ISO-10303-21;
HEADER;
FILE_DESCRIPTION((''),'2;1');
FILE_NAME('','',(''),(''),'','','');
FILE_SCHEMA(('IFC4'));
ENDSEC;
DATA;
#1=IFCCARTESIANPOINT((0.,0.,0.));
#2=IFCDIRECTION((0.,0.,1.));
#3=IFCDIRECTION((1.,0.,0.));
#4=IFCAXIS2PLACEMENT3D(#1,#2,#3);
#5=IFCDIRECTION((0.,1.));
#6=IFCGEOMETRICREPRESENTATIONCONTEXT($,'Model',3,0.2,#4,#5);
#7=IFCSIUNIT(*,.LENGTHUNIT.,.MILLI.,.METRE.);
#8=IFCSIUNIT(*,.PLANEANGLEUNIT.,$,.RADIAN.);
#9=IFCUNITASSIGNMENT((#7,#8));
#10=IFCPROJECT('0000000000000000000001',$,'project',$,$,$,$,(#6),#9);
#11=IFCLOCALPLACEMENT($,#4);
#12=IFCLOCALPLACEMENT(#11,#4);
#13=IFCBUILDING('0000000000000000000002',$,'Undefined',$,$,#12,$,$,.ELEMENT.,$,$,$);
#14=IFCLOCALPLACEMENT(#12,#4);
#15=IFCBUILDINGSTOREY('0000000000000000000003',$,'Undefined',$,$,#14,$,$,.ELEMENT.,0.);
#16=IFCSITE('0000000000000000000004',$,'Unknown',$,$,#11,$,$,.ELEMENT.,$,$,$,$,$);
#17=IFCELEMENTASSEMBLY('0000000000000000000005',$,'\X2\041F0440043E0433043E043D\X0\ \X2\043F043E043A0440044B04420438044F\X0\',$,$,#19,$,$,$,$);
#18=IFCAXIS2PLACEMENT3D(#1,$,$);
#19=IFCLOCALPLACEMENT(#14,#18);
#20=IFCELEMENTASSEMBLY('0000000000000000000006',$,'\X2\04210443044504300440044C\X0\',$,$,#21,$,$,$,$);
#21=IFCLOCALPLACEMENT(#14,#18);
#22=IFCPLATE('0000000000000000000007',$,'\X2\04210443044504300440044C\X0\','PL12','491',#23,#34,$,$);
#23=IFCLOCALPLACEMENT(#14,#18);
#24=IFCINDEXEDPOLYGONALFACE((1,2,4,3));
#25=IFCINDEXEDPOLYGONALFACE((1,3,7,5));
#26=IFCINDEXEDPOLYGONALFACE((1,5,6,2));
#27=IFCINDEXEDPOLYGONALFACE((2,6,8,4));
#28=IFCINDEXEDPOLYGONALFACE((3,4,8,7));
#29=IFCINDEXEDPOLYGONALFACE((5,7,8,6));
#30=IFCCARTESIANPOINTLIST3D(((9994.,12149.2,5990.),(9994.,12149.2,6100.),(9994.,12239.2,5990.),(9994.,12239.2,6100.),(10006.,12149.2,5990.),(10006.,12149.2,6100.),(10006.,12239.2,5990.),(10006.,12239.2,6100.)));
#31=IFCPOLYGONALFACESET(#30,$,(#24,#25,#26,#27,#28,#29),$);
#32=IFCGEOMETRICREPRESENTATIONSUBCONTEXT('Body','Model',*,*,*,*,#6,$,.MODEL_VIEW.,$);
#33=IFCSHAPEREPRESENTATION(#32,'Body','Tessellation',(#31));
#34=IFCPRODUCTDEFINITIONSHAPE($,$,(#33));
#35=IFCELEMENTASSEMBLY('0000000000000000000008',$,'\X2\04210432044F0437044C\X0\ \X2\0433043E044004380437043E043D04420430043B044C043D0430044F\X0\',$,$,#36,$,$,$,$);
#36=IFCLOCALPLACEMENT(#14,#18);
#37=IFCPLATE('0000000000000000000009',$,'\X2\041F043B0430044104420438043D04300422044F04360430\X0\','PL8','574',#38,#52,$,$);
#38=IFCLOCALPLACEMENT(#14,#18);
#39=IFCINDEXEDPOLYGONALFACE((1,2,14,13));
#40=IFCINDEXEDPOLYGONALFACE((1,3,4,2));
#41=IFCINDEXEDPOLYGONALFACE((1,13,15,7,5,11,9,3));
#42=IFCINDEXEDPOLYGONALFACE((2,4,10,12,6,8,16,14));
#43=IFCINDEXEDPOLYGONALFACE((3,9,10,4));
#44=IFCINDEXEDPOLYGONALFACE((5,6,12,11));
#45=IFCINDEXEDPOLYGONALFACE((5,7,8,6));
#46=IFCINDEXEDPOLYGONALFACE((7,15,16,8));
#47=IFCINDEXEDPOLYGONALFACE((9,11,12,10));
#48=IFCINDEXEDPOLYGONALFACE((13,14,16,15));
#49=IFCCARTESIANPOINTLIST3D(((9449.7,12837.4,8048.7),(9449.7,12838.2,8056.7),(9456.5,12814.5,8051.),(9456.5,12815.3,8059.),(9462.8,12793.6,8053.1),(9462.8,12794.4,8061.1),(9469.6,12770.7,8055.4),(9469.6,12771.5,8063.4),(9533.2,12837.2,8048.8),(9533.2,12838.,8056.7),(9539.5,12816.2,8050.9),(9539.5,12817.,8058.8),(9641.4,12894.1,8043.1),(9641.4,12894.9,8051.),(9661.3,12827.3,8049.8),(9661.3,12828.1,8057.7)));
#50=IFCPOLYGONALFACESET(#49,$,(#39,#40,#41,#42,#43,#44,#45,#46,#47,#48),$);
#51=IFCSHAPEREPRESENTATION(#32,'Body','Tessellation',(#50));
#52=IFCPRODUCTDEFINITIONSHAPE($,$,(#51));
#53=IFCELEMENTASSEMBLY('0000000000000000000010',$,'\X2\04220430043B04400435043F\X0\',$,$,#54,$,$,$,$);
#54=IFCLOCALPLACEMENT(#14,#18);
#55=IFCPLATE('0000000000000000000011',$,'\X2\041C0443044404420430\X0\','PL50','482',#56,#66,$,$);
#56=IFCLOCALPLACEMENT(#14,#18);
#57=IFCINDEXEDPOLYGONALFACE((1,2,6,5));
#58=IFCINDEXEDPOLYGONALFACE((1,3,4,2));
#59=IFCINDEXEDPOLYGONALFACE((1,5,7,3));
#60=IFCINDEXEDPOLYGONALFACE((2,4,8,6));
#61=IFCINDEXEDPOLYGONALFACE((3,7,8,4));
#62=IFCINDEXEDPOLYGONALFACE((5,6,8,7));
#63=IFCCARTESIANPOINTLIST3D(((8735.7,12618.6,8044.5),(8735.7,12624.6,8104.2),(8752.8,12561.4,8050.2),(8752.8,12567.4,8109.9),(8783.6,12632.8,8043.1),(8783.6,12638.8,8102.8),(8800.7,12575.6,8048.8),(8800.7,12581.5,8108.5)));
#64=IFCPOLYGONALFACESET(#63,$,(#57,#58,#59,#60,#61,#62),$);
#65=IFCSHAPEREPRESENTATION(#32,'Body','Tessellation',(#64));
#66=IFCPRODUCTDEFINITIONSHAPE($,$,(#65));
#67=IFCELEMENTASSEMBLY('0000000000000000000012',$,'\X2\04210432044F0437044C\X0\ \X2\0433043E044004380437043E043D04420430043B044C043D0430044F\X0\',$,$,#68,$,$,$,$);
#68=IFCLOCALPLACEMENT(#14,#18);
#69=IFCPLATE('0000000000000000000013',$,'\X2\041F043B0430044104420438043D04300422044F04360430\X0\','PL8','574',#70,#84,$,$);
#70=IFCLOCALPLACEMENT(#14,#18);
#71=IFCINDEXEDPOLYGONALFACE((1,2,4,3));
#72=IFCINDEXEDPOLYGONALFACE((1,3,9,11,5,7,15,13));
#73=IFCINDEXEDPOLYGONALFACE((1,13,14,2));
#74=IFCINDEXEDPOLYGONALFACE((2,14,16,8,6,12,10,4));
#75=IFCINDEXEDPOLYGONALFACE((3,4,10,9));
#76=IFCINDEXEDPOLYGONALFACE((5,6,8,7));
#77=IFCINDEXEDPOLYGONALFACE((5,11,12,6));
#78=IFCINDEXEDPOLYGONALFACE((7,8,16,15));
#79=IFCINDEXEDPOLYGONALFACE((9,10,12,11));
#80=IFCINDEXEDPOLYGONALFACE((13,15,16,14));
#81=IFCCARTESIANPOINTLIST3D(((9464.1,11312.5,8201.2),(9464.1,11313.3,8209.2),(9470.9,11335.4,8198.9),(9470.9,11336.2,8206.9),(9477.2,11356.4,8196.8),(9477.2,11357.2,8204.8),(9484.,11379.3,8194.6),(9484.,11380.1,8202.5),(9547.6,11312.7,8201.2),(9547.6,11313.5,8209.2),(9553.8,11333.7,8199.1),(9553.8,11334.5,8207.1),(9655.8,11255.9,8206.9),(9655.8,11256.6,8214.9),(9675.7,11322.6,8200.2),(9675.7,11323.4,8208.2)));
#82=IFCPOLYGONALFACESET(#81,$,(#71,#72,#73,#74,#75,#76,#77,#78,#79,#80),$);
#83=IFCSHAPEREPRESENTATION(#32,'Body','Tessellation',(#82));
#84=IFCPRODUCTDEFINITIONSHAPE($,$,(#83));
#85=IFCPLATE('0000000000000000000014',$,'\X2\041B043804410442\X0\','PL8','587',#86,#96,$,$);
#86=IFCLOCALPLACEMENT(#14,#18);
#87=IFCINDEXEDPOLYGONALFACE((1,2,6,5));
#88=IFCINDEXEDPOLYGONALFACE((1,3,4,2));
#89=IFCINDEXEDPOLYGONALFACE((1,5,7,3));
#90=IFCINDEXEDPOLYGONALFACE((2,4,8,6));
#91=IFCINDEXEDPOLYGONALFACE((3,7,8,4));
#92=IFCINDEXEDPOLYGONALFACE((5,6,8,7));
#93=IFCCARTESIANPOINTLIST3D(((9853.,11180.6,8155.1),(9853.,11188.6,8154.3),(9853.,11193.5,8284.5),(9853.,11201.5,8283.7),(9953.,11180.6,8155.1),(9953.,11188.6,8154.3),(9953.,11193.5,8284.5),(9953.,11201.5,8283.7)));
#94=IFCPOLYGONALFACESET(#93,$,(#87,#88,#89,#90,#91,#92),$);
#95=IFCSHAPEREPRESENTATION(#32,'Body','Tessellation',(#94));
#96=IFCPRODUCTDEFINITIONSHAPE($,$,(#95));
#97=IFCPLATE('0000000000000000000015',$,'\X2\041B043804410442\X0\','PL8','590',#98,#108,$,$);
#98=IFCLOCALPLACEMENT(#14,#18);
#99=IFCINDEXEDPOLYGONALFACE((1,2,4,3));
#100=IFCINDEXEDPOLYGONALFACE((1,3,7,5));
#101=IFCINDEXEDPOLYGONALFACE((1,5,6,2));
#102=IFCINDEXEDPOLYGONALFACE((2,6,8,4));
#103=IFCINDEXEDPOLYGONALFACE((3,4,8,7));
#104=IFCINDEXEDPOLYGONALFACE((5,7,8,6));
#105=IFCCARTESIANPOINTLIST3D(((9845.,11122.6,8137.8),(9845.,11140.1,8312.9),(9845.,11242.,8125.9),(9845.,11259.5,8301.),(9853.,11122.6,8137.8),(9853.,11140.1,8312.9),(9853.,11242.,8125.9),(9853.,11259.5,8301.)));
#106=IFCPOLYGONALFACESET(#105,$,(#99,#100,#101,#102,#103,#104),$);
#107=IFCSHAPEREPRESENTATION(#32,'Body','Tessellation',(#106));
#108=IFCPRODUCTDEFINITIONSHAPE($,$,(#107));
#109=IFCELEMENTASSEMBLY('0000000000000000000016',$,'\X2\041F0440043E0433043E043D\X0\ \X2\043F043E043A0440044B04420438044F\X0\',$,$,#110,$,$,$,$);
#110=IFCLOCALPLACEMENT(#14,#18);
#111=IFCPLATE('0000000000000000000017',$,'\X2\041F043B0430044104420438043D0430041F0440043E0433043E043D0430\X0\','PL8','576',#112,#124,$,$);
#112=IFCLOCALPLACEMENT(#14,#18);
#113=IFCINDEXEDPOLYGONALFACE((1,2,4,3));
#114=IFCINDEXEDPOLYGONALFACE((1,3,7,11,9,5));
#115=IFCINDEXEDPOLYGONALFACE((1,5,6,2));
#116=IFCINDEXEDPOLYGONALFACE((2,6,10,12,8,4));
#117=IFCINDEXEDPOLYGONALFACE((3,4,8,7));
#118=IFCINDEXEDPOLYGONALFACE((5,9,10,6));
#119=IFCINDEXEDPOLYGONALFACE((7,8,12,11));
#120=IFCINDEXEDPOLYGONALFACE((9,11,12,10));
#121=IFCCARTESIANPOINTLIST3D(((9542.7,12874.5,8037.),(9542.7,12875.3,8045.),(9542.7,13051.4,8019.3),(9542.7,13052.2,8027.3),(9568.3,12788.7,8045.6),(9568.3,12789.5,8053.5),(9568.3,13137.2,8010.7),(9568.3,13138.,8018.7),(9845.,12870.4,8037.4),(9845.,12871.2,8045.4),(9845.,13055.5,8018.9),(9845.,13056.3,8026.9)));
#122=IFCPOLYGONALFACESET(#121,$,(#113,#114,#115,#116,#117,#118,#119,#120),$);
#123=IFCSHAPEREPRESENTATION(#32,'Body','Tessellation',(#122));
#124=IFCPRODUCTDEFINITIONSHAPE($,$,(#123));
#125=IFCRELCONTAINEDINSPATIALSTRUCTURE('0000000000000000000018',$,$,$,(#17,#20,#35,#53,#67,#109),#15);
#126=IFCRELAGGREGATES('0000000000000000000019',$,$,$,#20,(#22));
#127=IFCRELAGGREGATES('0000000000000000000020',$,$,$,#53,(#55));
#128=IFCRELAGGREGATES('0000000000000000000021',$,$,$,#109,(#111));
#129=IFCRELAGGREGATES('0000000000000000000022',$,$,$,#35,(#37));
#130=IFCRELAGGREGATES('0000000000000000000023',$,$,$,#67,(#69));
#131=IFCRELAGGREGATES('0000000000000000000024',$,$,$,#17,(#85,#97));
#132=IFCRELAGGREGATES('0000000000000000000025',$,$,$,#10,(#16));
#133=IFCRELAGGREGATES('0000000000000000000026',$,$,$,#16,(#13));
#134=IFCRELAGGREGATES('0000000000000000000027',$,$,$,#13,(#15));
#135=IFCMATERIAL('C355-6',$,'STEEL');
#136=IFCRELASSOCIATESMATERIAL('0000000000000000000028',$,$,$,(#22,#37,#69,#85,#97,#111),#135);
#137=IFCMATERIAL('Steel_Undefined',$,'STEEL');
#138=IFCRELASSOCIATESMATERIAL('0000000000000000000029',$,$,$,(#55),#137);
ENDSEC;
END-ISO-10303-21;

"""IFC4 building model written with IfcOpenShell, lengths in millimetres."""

from ifc_helpers import new_model, si_unit, direction, frame, origin_with_axes, place, context, subcontext, project, spatial, line, indexed_curve, outline, extrude, material, element, aggregate, save


model = new_model("IFC4")

# Units and contexts
model_context = context("Model", 3, precision=0.2, world=origin_with_axes(), true_north=direction((0.0, 1.0)))
body_context = subcontext(model_context, "Body", "Model", "MODEL_VIEW")
ifc_project = project(units=[si_unit("LENGTHUNIT", "METRE", prefix="MILLI"), si_unit("PLANEANGLEUNIT", "RADIAN")], contexts=[model_context])

# Site, building, storey
site_placement = place(None, origin_with_axes())
site = spatial("IfcSite", under=ifc_project, at=site_placement, Name="Unknown", CompositionType="ELEMENT")
building_placement = place(site_placement, origin_with_axes())
building = spatial("IfcBuilding", under=site, at=building_placement, Name="Undefined", CompositionType="ELEMENT")
storey_placement = place(building_placement, origin_with_axes())
storey = spatial("IfcBuildingStorey", under=building, at=storey_placement, Name="Undefined", CompositionType="ELEMENT", Elevation=0.0)

# Shared definitions
ifc_material_1 = material(Name="C355-6", Category="STEEL")

# Element assembly
assembly_1_placement = place(storey_placement, frame((10000.0, 11191.0, 8219.4), z_axis=(0.0, -0.995037, 0.099504), x_axis=(-1.0, 0.0, 0.0)))
assembly_1 = element("IfcElementAssembly", 1, at=assembly_1_placement, inside=storey, Name="Прогон покрытия")

# Element assembly, plate
assembly_2_placement = place(storey_placement, frame((10000.0, 12149.2, 6100.0), z_axis=(-1.0, 0.0, 0.0), x_axis=(0.0, 1.0, 0.0)))
assembly_2 = element("IfcElementAssembly", 2, at=assembly_2_placement, inside=storey, Name="Сухарь")
plate_1_placement = place(assembly_2_placement, origin_with_axes())
plate_1 = element("IfcPlate", 3, at=plate_1_placement, material=ifc_material_1, Name="Сухарь", Description="PL12", ObjectType="491", context=body_context, shape_type="SolidModel", body=[
    extrude(outline(indexed_curve([(0.0, 0.0), (90.0, 0.0), (90.0, 110.0), (0.0, 110.0)], segments=[line(1, 2, 3, 4, 1)])), frame((0.0, 0.0, 6.0), z_axis=(0.0, 0.0, 1.0), x_axis=(1.0, 0.0, 0.0)), (0.0, 0.0, -1.0), 12.0),
])
aggregate(assembly_2, [plate_1])

# Element assembly, plate, voiding feature
assembly_3_placement = place(storey_placement, frame((8657.9, 12567.5, 8079.8), z_axis=(0.28473, -0.95385, 0.095385), x_axis=(0.958608, 0.283317, -0.028332)))
assembly_3 = element("IfcElementAssembly", 4, at=assembly_3_placement, inside=storey, Name="Связь горизонтальная")
plate_2_placement = place(assembly_3_placement, frame((1036.3, 0.0, 35.0), z_axis=(0.0, 1.0, 0.0), x_axis=(0.0, 0.0, -1.0)))
plate_2 = element("IfcPlate", 5, at=plate_2_placement, material=ifc_material_1, Name="ПластинаТяжа", Description="PL8", ObjectType="574", context=body_context, shape_type="SolidModel", body=[
    extrude(outline(indexed_curve([(0.0, 0.0), (70.0, 0.0), (70.0, 200.0), (0.0, 200.0)], segments=[line(1, 2, 3, 4, 1)])), frame((0.0, 0.0, 4.0), z_axis=(0.0, 0.0, 1.0), x_axis=(1.0, 0.0, 0.0)), (0.0, 0.0, -1.0), 8.0),
])
voiding_feature_1_placement = place(plate_2_placement, frame((24.0, 120.0, 0.0), z_axis=(0.0, 0.0, 1.0), x_axis=(1.0, 0.0, 0.0)))
element("IfcVoidingFeature", 6, at=voiding_feature_1_placement, cuts=plate_2, Name="PLATE", ObjectType="(?)", PredefinedType="HOLE", context=body_context, shape_type="SolidModel", body=[
    extrude(outline(indexed_curve([(0.0, 0.0), (22.0, 0.0), (22.0, 85.0), (0.0, 85.0)], segments=[line(1, 2, 3, 4, 1)])), frame((0.0, 0.0, 6.5), z_axis=(0.0, 0.0, 1.0), x_axis=(1.0, 0.0, 0.0)), (0.0, 0.0, -1.0), 13.0),
])

# Element assembly, plate
assembly_4_placement = place(storey_placement, frame((8776.7, 12574.5, 8109.2), z_axis=(-0.958608, -0.283317, 0.028332), x_axis=(-0.28473, 0.95385, -0.095385)))
assembly_4 = element("IfcElementAssembly", 7, at=assembly_4_placement, inside=storey, Name="Талреп")
ifc_material_2 = material(Name="Steel_Undefined", Category="STEEL")
plate_3_placement = place(assembly_4_placement, origin_with_axes())
plate_3 = element("IfcPlate", 8, at=plate_3_placement, material=ifc_material_2, Name="Муфта", Description="PL50", ObjectType="482", context=body_context, shape_type="SolidModel", body=[
    extrude(outline(indexed_curve([(0.0, 0.0), (60.0, 0.0), (60.0, 60.0), (0.0, 60.0)], segments=[line(1, 2, 3, 4, 1)])), frame((0.0, 0.0, 25.0), z_axis=(0.0, 0.0, 1.0), x_axis=(1.0, 0.0, 0.0)), (0.0, 0.0, -1.0), 50.0),
])
aggregate(assembly_4, [plate_3])

# Element assembly, plate, voiding feature
assembly_5_placement = place(storey_placement, frame((8657.9, 11587.5, 8177.8), z_axis=(-0.28473, -0.95385, 0.095385), x_axis=(0.958608, -0.283317, 0.028332)))
assembly_5 = element("IfcElementAssembly", 9, at=assembly_5_placement, inside=storey, Name="Связь горизонтальная")
plate_4_placement = place(assembly_5_placement, frame((1051.3, 0.0, 35.0), z_axis=(0.0, 1.0, 0.0), x_axis=(0.0, 0.0, -1.0)))
plate_4 = element("IfcPlate", 10, at=plate_4_placement, material=ifc_material_1, Name="ПластинаТяжа", Description="PL8", ObjectType="574", context=body_context, shape_type="SolidModel", body=[
    extrude(outline(indexed_curve([(0.0, 0.0), (70.0, 0.0), (70.0, 200.0), (0.0, 200.0)], segments=[line(1, 2, 3, 4, 1)])), frame((0.0, 0.0, 4.0), z_axis=(0.0, 0.0, 1.0), x_axis=(1.0, 0.0, 0.0)), (0.0, 0.0, -1.0), 8.0),
])
voiding_feature_2_placement = place(plate_4_placement, frame((24.0, 120.0, 0.0), z_axis=(0.0, 0.0, 1.0), x_axis=(1.0, 0.0, 0.0)))
element("IfcVoidingFeature", 11, at=voiding_feature_2_placement, cuts=plate_4, Name="PLATE", ObjectType="(?)", PredefinedType="HOLE", context=body_context, shape_type="SolidModel", body=[
    extrude(outline(indexed_curve([(0.0, 0.0), (22.0, 0.0), (22.0, 85.0), (0.0, 85.0)], segments=[line(1, 2, 3, 4, 1)])), frame((0.0, 0.0, 6.5), z_axis=(0.0, 0.0, 1.0), x_axis=(1.0, 0.0, 0.0)), (0.0, 0.0, -1.0), 13.0),
])

# Plates
plate_5_placement = place(assembly_1_placement, frame((47.0, -65.0, 0.0), z_axis=(0.0, 0.0, 1.0), x_axis=(1.0, 0.0, 0.0)))
plate_5 = element("IfcPlate", 12, at=plate_5_placement, material=ifc_material_1, Name="Лист", Description="PL8", ObjectType="587", context=body_context, shape_type="SolidModel", body=[
    extrude(outline(indexed_curve([(0.0, 0.0), (100.0, 0.0), (100.0, 130.0), (0.0, 130.0)], segments=[line(1, 2, 3, 4, 1)])), frame((0.0, 0.0, 4.0), z_axis=(0.0, 0.0, 1.0), x_axis=(1.0, 0.0, 0.0)), (0.0, 0.0, -1.0), 8.0),
])
plate_6_placement = place(assembly_1_placement, frame((151.0, -88.0, -60.0), z_axis=(-1.0, 0.0, 0.0), x_axis=(0.0, 0.0, 1.0)))
plate_6 = element("IfcPlate", 13, at=plate_6_placement, material=ifc_material_1, Name="Лист", Description="PL8", ObjectType="590", context=body_context, shape_type="SolidModel", body=[
    extrude(outline(indexed_curve([(0.0, 0.0), (120.0, 0.0), (120.0, 176.0), (0.0, 176.0)], segments=[line(1, 2, 3, 4, 1)])), frame((0.0, 0.0, 4.0), z_axis=(0.0, 0.0, 1.0), x_axis=(1.0, 0.0, 0.0)), (0.0, 0.0, -1.0), 8.0),
])

# Element assembly, plate
assembly_6_placement = place(storey_placement, frame((10000.0, 12963.3, 8032.1), z_axis=(0.0, -0.995037, 0.099504), x_axis=(-1.0, 0.0, 0.0)))
assembly_6 = element("IfcElementAssembly", 14, at=assembly_6_placement, inside=storey, Name="Прогон покрытия")
plate_7_placement = place(assembly_6_placement, frame((155.0, 0.0, 93.0), z_axis=(0.0, -1.0, 0.0), x_axis=(0.0, 0.0, -1.0)))
plate_7 = element("IfcPlate", 15, at=plate_7_placement, material=ifc_material_1, Name="ПластинаПрогона", Description="PL8", ObjectType="576", context=body_context, shape_type="SolidModel", body=[
    extrude(outline(indexed_curve([(0.0, 0.0), (186.0, 0.0), (268.1, 276.7), (181.9, 302.3), (4.1, 302.3), (-82.2, 276.7)], segments=[line(1, 2, 3, 4, 5, 6, 1)])), frame((0.0, 0.0, 4.0), z_axis=(0.0, 0.0, 1.0), x_axis=(1.0, 0.0, 0.0)), (0.0, 0.0, -1.0), 8.0),
])
aggregate(assembly_6, [plate_7])

aggregate(assembly_3, [plate_2])
aggregate(assembly_5, [plate_4])
aggregate(assembly_1, [plate_5, plate_6])

save(model, "model.ifc")
